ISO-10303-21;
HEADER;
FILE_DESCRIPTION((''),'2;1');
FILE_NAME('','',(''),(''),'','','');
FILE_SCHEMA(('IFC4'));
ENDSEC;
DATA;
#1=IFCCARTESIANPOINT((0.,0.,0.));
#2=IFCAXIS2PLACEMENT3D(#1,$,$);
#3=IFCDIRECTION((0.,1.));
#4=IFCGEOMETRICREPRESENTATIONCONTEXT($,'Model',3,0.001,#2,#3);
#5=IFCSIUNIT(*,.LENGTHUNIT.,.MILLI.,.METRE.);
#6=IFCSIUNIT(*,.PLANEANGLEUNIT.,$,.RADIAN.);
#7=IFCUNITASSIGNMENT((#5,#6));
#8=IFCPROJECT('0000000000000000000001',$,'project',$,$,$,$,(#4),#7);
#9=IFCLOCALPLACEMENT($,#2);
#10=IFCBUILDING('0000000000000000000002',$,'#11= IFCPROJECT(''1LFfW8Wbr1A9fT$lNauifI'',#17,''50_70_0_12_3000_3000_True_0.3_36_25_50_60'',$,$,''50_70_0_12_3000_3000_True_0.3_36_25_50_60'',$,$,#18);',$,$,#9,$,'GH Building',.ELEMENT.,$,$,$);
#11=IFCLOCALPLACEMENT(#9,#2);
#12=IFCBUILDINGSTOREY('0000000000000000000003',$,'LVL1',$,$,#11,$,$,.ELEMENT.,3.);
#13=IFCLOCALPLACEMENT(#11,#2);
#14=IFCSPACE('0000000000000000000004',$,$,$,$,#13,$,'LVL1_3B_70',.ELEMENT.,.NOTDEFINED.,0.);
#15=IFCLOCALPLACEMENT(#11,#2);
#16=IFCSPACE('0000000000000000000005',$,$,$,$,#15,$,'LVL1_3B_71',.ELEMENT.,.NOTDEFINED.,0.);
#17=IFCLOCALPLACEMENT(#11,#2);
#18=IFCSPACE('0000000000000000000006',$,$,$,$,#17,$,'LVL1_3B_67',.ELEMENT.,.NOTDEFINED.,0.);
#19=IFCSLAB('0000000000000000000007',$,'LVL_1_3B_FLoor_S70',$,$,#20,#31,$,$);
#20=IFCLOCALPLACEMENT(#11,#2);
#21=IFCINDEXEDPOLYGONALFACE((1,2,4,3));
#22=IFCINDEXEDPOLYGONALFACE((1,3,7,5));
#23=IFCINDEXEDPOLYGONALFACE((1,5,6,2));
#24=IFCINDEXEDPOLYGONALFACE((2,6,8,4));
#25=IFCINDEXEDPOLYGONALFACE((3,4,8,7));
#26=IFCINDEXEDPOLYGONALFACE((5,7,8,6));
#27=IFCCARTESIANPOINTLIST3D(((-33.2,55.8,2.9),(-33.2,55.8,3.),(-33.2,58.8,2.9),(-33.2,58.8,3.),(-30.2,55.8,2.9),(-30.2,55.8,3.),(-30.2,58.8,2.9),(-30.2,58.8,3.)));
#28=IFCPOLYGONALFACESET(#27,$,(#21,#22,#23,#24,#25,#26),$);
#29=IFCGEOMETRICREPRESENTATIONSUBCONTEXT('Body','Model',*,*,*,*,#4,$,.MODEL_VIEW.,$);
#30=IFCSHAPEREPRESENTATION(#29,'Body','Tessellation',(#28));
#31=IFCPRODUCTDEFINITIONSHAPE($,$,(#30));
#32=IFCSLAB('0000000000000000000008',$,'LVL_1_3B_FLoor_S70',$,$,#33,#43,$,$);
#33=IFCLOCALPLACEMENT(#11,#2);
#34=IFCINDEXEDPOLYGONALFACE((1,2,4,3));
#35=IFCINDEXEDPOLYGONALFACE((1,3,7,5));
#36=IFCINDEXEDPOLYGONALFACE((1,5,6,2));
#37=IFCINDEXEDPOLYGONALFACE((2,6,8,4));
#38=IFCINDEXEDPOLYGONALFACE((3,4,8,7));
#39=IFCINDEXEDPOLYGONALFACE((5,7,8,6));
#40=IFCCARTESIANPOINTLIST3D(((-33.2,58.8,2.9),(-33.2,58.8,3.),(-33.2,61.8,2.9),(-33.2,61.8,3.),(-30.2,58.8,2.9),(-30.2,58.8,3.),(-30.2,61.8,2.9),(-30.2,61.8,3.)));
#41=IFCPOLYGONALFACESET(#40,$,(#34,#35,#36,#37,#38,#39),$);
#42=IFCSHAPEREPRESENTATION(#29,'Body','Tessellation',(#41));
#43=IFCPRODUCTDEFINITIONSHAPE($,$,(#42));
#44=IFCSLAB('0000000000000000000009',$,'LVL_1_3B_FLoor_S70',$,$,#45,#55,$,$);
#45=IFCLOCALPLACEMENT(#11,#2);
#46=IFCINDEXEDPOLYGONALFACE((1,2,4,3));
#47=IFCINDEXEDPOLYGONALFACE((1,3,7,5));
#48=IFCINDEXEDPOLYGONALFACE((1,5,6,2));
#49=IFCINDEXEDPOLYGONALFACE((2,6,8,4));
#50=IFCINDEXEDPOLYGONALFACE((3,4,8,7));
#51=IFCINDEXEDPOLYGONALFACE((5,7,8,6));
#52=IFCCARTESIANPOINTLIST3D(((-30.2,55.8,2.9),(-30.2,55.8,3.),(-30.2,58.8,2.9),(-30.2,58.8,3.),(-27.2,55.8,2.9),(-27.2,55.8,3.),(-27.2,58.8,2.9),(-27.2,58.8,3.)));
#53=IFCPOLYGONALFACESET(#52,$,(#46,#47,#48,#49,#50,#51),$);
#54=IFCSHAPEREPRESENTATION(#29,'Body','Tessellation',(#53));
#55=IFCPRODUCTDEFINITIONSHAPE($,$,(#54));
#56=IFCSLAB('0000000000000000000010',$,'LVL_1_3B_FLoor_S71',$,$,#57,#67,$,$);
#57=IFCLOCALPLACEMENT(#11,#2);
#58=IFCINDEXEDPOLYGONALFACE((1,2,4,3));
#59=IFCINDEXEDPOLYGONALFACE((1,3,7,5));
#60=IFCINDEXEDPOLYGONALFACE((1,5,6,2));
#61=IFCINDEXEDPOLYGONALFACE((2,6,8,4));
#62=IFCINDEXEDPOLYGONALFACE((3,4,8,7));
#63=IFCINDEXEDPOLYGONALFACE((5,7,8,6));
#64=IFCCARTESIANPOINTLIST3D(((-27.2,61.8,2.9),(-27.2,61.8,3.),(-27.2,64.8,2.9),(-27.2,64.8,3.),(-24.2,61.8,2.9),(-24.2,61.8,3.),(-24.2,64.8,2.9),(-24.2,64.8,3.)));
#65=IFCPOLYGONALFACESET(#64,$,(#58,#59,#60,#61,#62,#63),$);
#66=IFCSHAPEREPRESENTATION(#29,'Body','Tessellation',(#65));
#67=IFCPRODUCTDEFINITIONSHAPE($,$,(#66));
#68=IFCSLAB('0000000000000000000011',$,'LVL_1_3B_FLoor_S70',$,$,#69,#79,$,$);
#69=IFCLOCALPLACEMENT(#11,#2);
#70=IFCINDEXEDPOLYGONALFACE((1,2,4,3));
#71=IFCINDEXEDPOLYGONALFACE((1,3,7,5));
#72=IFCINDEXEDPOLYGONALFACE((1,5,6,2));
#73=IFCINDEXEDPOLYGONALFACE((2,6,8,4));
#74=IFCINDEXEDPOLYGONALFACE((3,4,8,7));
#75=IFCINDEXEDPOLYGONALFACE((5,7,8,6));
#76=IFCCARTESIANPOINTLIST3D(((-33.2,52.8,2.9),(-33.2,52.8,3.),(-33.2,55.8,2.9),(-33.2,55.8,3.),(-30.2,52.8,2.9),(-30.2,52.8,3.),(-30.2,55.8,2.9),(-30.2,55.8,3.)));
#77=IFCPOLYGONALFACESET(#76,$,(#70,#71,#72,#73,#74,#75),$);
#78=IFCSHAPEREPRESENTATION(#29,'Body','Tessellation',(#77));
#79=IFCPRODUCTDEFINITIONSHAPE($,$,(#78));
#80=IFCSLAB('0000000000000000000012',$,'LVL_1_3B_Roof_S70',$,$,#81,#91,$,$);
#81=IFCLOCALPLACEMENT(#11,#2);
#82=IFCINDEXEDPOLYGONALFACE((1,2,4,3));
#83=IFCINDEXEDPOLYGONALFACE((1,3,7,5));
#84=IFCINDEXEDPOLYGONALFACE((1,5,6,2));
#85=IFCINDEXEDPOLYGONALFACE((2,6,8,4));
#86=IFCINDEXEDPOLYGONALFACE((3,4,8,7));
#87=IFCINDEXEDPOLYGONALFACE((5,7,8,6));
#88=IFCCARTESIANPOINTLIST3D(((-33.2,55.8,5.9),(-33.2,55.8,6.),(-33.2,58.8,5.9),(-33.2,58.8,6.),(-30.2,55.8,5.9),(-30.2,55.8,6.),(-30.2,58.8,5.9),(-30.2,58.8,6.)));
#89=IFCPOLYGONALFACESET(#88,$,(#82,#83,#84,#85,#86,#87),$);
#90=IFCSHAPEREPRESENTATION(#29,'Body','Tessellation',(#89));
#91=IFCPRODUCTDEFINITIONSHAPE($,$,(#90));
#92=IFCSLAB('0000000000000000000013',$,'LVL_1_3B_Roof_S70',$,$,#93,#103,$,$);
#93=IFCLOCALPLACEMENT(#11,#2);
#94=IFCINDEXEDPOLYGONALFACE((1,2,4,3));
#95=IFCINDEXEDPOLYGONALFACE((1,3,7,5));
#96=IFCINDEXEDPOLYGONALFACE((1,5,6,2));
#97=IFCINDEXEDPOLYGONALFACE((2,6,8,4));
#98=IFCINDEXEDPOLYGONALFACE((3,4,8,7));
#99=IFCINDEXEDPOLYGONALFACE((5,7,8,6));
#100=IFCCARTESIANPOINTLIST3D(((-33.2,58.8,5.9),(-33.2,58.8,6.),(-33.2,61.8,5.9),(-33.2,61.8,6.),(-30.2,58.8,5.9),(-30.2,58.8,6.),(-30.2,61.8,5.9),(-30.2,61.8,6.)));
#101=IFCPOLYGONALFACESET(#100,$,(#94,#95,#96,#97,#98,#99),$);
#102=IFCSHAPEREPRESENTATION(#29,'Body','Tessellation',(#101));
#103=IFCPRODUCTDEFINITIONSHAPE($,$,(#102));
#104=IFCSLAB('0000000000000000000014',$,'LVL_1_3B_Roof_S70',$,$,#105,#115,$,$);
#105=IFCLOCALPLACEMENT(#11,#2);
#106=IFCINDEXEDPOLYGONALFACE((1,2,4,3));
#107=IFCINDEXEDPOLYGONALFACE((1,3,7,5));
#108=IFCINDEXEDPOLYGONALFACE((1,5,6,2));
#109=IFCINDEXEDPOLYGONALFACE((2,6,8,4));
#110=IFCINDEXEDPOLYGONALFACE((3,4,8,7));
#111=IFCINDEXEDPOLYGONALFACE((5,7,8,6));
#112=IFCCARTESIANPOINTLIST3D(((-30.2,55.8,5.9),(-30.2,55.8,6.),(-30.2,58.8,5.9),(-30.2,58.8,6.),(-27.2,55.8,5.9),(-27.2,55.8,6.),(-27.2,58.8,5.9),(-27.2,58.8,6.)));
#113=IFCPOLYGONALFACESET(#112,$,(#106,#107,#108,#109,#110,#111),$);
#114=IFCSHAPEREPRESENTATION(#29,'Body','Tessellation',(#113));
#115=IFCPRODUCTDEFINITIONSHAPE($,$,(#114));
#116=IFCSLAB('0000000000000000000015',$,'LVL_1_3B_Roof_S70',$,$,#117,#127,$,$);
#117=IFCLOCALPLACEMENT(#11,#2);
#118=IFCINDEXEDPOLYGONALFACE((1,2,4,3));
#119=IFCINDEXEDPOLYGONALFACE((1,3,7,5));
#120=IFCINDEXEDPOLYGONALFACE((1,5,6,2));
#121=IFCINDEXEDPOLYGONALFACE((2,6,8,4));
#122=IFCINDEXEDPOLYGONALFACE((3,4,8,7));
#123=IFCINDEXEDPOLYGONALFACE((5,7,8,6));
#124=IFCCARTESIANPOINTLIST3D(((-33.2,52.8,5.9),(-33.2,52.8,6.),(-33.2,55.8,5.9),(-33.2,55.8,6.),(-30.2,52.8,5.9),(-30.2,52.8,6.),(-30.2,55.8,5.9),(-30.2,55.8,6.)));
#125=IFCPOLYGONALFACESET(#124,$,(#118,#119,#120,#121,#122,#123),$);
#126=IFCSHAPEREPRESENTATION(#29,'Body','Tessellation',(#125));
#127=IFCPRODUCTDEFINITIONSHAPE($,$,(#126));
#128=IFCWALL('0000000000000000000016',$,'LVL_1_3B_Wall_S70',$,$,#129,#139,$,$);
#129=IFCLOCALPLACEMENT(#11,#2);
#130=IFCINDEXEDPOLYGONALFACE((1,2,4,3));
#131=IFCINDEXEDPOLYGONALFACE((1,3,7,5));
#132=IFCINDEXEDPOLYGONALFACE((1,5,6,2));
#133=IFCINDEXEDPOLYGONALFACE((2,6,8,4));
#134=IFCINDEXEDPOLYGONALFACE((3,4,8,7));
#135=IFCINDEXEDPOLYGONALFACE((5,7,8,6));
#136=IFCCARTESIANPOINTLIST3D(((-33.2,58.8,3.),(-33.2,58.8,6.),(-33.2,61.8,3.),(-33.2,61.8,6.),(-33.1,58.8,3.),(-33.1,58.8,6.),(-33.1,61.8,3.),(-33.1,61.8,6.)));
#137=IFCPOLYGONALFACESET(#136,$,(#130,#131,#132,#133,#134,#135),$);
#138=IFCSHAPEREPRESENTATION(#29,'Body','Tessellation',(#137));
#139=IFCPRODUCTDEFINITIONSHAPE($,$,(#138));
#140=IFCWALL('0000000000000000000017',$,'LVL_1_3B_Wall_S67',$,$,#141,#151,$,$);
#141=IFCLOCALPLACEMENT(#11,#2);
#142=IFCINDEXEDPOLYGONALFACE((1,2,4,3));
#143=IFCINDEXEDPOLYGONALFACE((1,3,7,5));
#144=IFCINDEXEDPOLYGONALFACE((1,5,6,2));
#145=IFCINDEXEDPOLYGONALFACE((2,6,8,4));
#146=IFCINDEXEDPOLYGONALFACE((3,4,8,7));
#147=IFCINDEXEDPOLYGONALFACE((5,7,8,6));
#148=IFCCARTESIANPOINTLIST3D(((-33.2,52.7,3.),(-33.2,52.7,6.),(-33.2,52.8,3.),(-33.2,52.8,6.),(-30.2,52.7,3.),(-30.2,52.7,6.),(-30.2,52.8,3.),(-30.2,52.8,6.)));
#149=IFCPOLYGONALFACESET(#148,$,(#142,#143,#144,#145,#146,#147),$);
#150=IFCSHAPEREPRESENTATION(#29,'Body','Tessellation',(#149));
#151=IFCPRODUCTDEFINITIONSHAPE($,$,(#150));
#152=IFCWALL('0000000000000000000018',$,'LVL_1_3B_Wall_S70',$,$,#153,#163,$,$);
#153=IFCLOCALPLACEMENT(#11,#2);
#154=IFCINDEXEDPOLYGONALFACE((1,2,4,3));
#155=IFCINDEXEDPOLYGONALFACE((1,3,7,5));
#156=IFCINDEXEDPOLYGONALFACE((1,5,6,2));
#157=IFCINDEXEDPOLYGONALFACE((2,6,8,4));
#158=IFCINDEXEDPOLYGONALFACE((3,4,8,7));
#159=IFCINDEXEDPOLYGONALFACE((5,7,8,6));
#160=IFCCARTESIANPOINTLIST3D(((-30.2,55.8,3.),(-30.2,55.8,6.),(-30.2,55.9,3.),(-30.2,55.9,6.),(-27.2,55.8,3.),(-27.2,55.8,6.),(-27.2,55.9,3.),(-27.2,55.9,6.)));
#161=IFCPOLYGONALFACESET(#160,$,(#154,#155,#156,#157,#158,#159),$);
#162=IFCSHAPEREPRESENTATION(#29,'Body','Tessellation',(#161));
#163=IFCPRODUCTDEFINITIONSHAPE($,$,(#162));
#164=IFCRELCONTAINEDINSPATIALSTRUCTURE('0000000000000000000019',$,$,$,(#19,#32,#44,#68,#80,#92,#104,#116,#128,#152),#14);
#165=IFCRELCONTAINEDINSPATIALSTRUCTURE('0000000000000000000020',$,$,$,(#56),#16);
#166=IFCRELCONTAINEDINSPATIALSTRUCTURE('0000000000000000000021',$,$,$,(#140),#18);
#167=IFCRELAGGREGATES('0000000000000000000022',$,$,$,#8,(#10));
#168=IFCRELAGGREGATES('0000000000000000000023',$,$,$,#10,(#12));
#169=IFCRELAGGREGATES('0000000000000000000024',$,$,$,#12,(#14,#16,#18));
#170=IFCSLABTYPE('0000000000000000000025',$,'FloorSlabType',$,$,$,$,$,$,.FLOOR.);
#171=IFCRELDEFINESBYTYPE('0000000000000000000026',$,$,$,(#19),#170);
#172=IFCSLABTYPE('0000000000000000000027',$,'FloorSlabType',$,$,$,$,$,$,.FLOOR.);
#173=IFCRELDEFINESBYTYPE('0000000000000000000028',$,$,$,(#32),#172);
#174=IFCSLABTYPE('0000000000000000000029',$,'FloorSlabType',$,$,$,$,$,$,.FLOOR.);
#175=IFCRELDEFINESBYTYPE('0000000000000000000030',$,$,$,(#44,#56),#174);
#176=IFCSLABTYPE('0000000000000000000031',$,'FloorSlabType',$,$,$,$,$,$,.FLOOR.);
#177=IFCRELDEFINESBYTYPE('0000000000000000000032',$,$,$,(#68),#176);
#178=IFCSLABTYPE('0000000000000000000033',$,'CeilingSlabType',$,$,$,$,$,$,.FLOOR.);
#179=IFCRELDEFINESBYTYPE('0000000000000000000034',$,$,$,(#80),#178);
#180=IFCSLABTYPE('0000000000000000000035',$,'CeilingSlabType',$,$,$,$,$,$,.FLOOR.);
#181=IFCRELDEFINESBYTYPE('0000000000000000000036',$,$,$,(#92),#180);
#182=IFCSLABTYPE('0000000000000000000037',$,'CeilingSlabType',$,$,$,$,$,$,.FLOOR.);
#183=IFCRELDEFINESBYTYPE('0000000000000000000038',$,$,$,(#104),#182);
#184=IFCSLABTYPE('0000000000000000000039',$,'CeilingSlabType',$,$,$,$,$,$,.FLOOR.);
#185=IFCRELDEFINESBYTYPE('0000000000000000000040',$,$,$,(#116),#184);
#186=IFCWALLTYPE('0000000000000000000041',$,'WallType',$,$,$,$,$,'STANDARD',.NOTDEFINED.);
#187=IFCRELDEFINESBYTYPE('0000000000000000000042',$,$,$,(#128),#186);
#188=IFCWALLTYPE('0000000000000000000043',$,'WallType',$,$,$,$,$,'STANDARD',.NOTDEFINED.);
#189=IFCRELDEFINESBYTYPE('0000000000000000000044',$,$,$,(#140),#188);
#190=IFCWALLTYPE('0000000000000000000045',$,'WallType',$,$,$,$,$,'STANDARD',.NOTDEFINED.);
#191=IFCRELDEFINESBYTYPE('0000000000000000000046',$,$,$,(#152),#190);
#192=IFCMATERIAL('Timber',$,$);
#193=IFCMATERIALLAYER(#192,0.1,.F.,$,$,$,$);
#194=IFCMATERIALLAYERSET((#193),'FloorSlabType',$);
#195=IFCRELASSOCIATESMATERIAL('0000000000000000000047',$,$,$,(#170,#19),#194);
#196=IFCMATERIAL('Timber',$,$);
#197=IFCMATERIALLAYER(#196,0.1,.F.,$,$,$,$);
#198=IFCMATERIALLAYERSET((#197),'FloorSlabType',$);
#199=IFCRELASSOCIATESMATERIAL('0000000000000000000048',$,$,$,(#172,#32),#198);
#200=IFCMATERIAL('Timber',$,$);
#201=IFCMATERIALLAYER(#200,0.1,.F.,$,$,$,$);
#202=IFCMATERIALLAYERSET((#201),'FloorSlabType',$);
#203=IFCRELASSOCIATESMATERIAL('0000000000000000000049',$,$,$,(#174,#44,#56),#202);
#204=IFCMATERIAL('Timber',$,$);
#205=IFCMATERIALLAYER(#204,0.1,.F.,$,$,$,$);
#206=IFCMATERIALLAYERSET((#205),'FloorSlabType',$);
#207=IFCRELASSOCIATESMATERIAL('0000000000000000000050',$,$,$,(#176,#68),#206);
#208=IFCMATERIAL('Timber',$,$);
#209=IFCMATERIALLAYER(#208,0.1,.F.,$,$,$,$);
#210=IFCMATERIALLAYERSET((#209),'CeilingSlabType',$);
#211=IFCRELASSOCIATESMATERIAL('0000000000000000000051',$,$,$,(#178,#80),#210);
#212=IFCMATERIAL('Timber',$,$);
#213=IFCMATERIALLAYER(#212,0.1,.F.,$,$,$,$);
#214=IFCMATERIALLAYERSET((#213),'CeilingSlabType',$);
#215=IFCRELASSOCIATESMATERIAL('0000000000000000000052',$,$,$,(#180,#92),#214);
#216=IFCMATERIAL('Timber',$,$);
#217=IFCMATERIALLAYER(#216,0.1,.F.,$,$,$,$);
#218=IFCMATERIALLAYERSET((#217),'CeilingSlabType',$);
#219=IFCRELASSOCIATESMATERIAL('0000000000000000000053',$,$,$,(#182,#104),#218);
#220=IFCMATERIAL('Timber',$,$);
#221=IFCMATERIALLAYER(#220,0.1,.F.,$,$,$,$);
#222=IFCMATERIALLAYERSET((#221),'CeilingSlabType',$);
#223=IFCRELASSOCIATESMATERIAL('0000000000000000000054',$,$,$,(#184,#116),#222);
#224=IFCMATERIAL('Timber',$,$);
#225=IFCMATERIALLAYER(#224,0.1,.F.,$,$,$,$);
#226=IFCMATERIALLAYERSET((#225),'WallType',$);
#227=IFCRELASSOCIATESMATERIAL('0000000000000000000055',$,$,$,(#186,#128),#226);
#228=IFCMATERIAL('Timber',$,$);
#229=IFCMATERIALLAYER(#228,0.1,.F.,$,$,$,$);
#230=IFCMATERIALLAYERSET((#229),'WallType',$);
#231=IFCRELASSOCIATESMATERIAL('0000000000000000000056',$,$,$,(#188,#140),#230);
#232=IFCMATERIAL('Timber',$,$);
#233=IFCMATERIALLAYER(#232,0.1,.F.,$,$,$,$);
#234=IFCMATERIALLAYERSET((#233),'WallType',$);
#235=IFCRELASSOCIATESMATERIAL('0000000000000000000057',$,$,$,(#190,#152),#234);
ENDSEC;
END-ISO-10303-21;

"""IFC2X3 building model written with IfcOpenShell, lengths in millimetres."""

from ifc_helpers import new_model, si_unit, direction, frame, frame_2d, origin, place, context, subcontext, project, spatial, rectangle, extrude, material, layer, layer_set, layer_usage, type_object, element, save


model = new_model("IFC2X3")

# Units and contexts
model_context = context("Model", 3, precision=0.001, world=origin(), true_north=direction((0.0, 1.0)))
body_context = subcontext(model_context, "Body", "Model", "MODEL_VIEW")
ifc_project = project(units=[si_unit("LENGTHUNIT", "METRE", prefix="MILLI"), si_unit("PLANEANGLEUNIT", "RADIAN")], contexts=[model_context])

# Building, storey
building_placement = place(None, origin())
building = spatial("IfcBuilding", under=ifc_project, at=building_placement, Name="#11= IFCPROJECT('1LFfW8Wbr1A9fT$lNauifI',#17,'50_70_0_12_3000_3000_True_0.3_36_25_50_60',$,$,'50_70_0_12_3000_3000_True_0.3_36_25_50_60',$,$,#18);", LongName="GH Building", CompositionType="ELEMENT")
storey_placement = place(building_placement, origin())
storey = spatial("IfcBuildingStorey", under=building, at=storey_placement, Name="LVL1", CompositionType="ELEMENT", Elevation=3.0)

# Shared definitions
space_1_placement = place(storey_placement, origin())
space_1 = spatial("IfcSpace", under=storey, at=space_1_placement, LongName="LVL1_3B_70", CompositionType="ELEMENT", InteriorOrExteriorSpace="NOTDEFINED", ElevationWithFlooring=0.0)

# Slabs
ifc_material_1 = material(Name="Timber")
ifc_layer_1 = layer(ifc_material_1, 0.1, ventilated=False)
ifc_layer_set_1 = layer_set([ifc_layer_1], Name="FloorSlabType")
ifc_layer_usage_1 = layer_usage(ifc_layer_set_1, "AXIS3", "NEGATIVE", -0.1)
slab_type_1 = type_object("IfcSlabType", Name="FloorSlabType", PredefinedType="FLOOR", material=ifc_layer_set_1)
slab_1_placement = place(space_1_placement, frame((-30.2, 55.8, 2.9), z_axis=(0.0, 0.0, 1.0), x_axis=(0.0, 1.0, 0.0)))
element("IfcSlab", 1, at=slab_1_placement, inside=space_1, type_object=slab_type_1, material=ifc_layer_usage_1, Name="LVL_1_3B_FLoor_S70", context=body_context, shape_type="SweptSolid", body=[
    extrude(rectangle(XDim=3.0, YDim=3.0, at=frame_2d((1.5, 1.5))), origin(), (0.0, 0.0, 1.0), 0.1),
])
ifc_material_2 = material(Name="Timber")
ifc_layer_2 = layer(ifc_material_2, 0.1, ventilated=False)
ifc_layer_set_2 = layer_set([ifc_layer_2], Name="FloorSlabType")
ifc_layer_usage_2 = layer_usage(ifc_layer_set_2, "AXIS3", "NEGATIVE", -0.1)
slab_type_2 = type_object("IfcSlabType", Name="FloorSlabType", PredefinedType="FLOOR", material=ifc_layer_set_2)
slab_2_placement = place(space_1_placement, frame((-30.2, 58.8, 2.9), z_axis=(0.0, 0.0, 1.0), x_axis=(0.0, 1.0, 0.0)))
element("IfcSlab", 2, at=slab_2_placement, inside=space_1, type_object=slab_type_2, material=ifc_layer_usage_2, Name="LVL_1_3B_FLoor_S70", context=body_context, shape_type="SweptSolid", body=[
    extrude(rectangle(XDim=3.0, YDim=3.0, at=frame_2d((1.5, 1.5))), origin(), (0.0, 0.0, 1.0), 0.1),
])
ifc_material_3 = material(Name="Timber")
ifc_layer_3 = layer(ifc_material_3, 0.1, ventilated=False)
ifc_layer_set_3 = layer_set([ifc_layer_3], Name="FloorSlabType")
ifc_layer_usage_3 = layer_usage(ifc_layer_set_3, "AXIS3", "NEGATIVE", -0.1)
slab_type_3 = type_object("IfcSlabType", Name="FloorSlabType", PredefinedType="FLOOR", material=ifc_layer_set_3)
slab_3_placement = place(space_1_placement, frame((-27.2, 55.8, 2.9), z_axis=(0.0, 0.0, 1.0), x_axis=(0.0, 1.0, 0.0)))
element("IfcSlab", 3, at=slab_3_placement, inside=space_1, type_object=slab_type_3, material=ifc_layer_usage_3, Name="LVL_1_3B_FLoor_S70", context=body_context, shape_type="SweptSolid", body=[
    extrude(rectangle(XDim=3.0, YDim=3.0, at=frame_2d((1.5, 1.5))), origin(), (0.0, 0.0, 1.0), 0.1),
])

# Shared definitions
space_2_placement = place(storey_placement, origin())
space_2 = spatial("IfcSpace", under=storey, at=space_2_placement, LongName="LVL1_3B_71", CompositionType="ELEMENT", InteriorOrExteriorSpace="NOTDEFINED", ElevationWithFlooring=0.0)

# Slabs
ifc_layer_usage_4 = layer_usage(ifc_layer_set_3, "AXIS3", "NEGATIVE", -0.1)
slab_4_placement = place(space_2_placement, frame((-27.2, 61.8, 2.9)))
element("IfcSlab", 4, at=slab_4_placement, inside=space_2, type_object=slab_type_3, material=ifc_layer_usage_4, Name="LVL_1_3B_FLoor_S71", context=body_context, shape_type="SweptSolid", body=[
    extrude(rectangle(XDim=3.0, YDim=3.0, at=frame_2d((1.5, 1.5))), origin(), (0.0, 0.0, 1.0), 0.1),
])
ifc_material_4 = material(Name="Timber")
ifc_layer_4 = layer(ifc_material_4, 0.1, ventilated=False)
ifc_layer_set_4 = layer_set([ifc_layer_4], Name="FloorSlabType")
ifc_layer_usage_5 = layer_usage(ifc_layer_set_4, "AXIS3", "NEGATIVE", -0.1)
slab_type_4 = type_object("IfcSlabType", Name="FloorSlabType", PredefinedType="FLOOR", material=ifc_layer_set_4)
slab_5_placement = place(space_1_placement, frame((-30.2, 52.8, 2.9), z_axis=(0.0, 0.0, 1.0), x_axis=(0.0, 1.0, 0.0)))
element("IfcSlab", 5, at=slab_5_placement, inside=space_1, type_object=slab_type_4, material=ifc_layer_usage_5, Name="LVL_1_3B_FLoor_S70", context=body_context, shape_type="SweptSolid", body=[
    extrude(rectangle(XDim=3.0, YDim=3.0, at=frame_2d((1.5, 1.5))), origin(), (0.0, 0.0, 1.0), 0.1),
])
ifc_material_5 = material(Name="Timber")
ifc_layer_5 = layer(ifc_material_5, 0.1, ventilated=False)
ifc_layer_set_5 = layer_set([ifc_layer_5], Name="CeilingSlabType")
ifc_layer_usage_6 = layer_usage(ifc_layer_set_5, "AXIS3", "NEGATIVE", -0.1)
slab_type_5 = type_object("IfcSlabType", Name="CeilingSlabType", PredefinedType="FLOOR", material=ifc_layer_set_5)
slab_6_placement = place(space_1_placement, frame((-30.2, 55.8, 5.9), z_axis=(0.0, 0.0, 1.0), x_axis=(0.0, 1.0, 0.0)))
element("IfcSlab", 6, at=slab_6_placement, inside=space_1, type_object=slab_type_5, material=ifc_layer_usage_6, Name="LVL_1_3B_Roof_S70", context=body_context, shape_type="SweptSolid", body=[
    extrude(rectangle(XDim=3.0, YDim=3.0, at=frame_2d((1.5, 1.5))), origin(), (0.0, 0.0, 1.0), 0.1),
])
ifc_material_6 = material(Name="Timber")
ifc_layer_6 = layer(ifc_material_6, 0.1, ventilated=False)
ifc_layer_set_6 = layer_set([ifc_layer_6], Name="CeilingSlabType")
ifc_layer_usage_7 = layer_usage(ifc_layer_set_6, "AXIS3", "NEGATIVE", -0.1)
slab_type_6 = type_object("IfcSlabType", Name="CeilingSlabType", PredefinedType="FLOOR", material=ifc_layer_set_6)
slab_7_placement = place(space_1_placement, frame((-30.2, 58.8, 5.9), z_axis=(0.0, 0.0, 1.0), x_axis=(0.0, 1.0, 0.0)))
element("IfcSlab", 7, at=slab_7_placement, inside=space_1, type_object=slab_type_6, material=ifc_layer_usage_7, Name="LVL_1_3B_Roof_S70", context=body_context, shape_type="SweptSolid", body=[
    extrude(rectangle(XDim=3.0, YDim=3.0, at=frame_2d((1.5, 1.5))), origin(), (0.0, 0.0, 1.0), 0.1),
])
ifc_material_7 = material(Name="Timber")
ifc_layer_7 = layer(ifc_material_7, 0.1, ventilated=False)
ifc_layer_set_7 = layer_set([ifc_layer_7], Name="CeilingSlabType")
ifc_layer_usage_8 = layer_usage(ifc_layer_set_7, "AXIS3", "NEGATIVE", -0.1)
slab_type_7 = type_object("IfcSlabType", Name="CeilingSlabType", PredefinedType="FLOOR", material=ifc_layer_set_7)
slab_8_placement = place(space_1_placement, frame((-27.2, 55.8, 5.9), z_axis=(0.0, 0.0, 1.0), x_axis=(0.0, 1.0, 0.0)))
element("IfcSlab", 8, at=slab_8_placement, inside=space_1, type_object=slab_type_7, material=ifc_layer_usage_8, Name="LVL_1_3B_Roof_S70", context=body_context, shape_type="SweptSolid", body=[
    extrude(rectangle(XDim=3.0, YDim=3.0, at=frame_2d((1.5, 1.5))), origin(), (0.0, 0.0, 1.0), 0.1),
])
ifc_material_8 = material(Name="Timber")
ifc_layer_8 = layer(ifc_material_8, 0.1, ventilated=False)
ifc_layer_set_8 = layer_set([ifc_layer_8], Name="CeilingSlabType")
ifc_layer_usage_9 = layer_usage(ifc_layer_set_8, "AXIS3", "NEGATIVE", -0.1)
slab_type_8 = type_object("IfcSlabType", Name="CeilingSlabType", PredefinedType="FLOOR", material=ifc_layer_set_8)
slab_9_placement = place(space_1_placement, frame((-30.2, 52.8, 5.9), z_axis=(0.0, 0.0, 1.0), x_axis=(0.0, 1.0, 0.0)))
element("IfcSlab", 9, at=slab_9_placement, inside=space_1, type_object=slab_type_8, material=ifc_layer_usage_9, Name="LVL_1_3B_Roof_S70", context=body_context, shape_type="SweptSolid", body=[
    extrude(rectangle(XDim=3.0, YDim=3.0, at=frame_2d((1.5, 1.5))), origin(), (0.0, 0.0, 1.0), 0.1),
])

# Shared definitions
space_3_placement = place(storey_placement, origin())
space_3 = spatial("IfcSpace", under=storey, at=space_3_placement, LongName="LVL1_3B_67", CompositionType="ELEMENT", InteriorOrExteriorSpace="NOTDEFINED", ElevationWithFlooring=0.0)

# Walls
ifc_material_9 = material(Name="Timber")
ifc_layer_9 = layer(ifc_material_9, 0.1, ventilated=False)
ifc_layer_set_9 = layer_set([ifc_layer_9], Name="WallType")
ifc_layer_usage_10 = layer_usage(ifc_layer_set_9, "AXIS2", "NEGATIVE", 0.0)
wall_type_1 = type_object("IfcWallType", Name="WallType", ElementType="STANDARD", PredefinedType="NOTDEFINED", material=ifc_layer_set_9)
wall_1_placement = place(space_1_placement, frame((-33.2, 58.8, 3.0), z_axis=(0.0, 0.0, 1.0), x_axis=(0.0, 1.0, 0.0)))
element("IfcWall", 10, at=wall_1_placement, inside=space_1, type_object=wall_type_1, material=ifc_layer_usage_10, Name="LVL_1_3B_Wall_S70", context=body_context, shape_type="SweptSolid", body=[
    extrude(rectangle(XDim=3.0, YDim=0.1, at=frame_2d((1.5, -0.1))), origin(), (0.0, 0.0, 1.0), 3.0),
])
ifc_material_10 = material(Name="Timber")
ifc_layer_10 = layer(ifc_material_10, 0.1, ventilated=False)
ifc_layer_set_10 = layer_set([ifc_layer_10], Name="WallType")
ifc_layer_usage_11 = layer_usage(ifc_layer_set_10, "AXIS2", "NEGATIVE", 0.0)
wall_type_2 = type_object("IfcWallType", Name="WallType", ElementType="STANDARD", PredefinedType="NOTDEFINED", material=ifc_layer_set_10)
wall_2_placement = place(space_3_placement, frame((-33.2, 52.8, 3.0)))
element("IfcWall", 11, at=wall_2_placement, inside=space_3, type_object=wall_type_2, material=ifc_layer_usage_11, Name="LVL_1_3B_Wall_S67", context=body_context, shape_type="SweptSolid", body=[
    extrude(rectangle(XDim=3.0, YDim=0.1, at=frame_2d((1.5, -0.1))), origin(), (0.0, 0.0, 1.0), 3.0),
])
ifc_material_11 = material(Name="Timber")
ifc_layer_11 = layer(ifc_material_11, 0.1, ventilated=False)
ifc_layer_set_11 = layer_set([ifc_layer_11], Name="WallType")
ifc_layer_usage_12 = layer_usage(ifc_layer_set_11, "AXIS2", "NEGATIVE", 0.0)
wall_type_3 = type_object("IfcWallType", Name="WallType", ElementType="STANDARD", PredefinedType="NOTDEFINED", material=ifc_layer_set_11)
wall_3_placement = place(space_1_placement, frame((-27.2, 55.8, 3.0), z_axis=(0.0, 0.0, 1.0), x_axis=(-1.0, 0.0, 0.0)))
element("IfcWall", 12, at=wall_3_placement, inside=space_1, type_object=wall_type_3, material=ifc_layer_usage_12, Name="LVL_1_3B_Wall_S70", context=body_context, shape_type="SweptSolid", body=[
    extrude(rectangle(XDim=3.0, YDim=0.1, at=frame_2d((1.5, -0.1))), origin(), (0.0, 0.0, 1.0), 3.0),
])

save(model, "model.ifc")
